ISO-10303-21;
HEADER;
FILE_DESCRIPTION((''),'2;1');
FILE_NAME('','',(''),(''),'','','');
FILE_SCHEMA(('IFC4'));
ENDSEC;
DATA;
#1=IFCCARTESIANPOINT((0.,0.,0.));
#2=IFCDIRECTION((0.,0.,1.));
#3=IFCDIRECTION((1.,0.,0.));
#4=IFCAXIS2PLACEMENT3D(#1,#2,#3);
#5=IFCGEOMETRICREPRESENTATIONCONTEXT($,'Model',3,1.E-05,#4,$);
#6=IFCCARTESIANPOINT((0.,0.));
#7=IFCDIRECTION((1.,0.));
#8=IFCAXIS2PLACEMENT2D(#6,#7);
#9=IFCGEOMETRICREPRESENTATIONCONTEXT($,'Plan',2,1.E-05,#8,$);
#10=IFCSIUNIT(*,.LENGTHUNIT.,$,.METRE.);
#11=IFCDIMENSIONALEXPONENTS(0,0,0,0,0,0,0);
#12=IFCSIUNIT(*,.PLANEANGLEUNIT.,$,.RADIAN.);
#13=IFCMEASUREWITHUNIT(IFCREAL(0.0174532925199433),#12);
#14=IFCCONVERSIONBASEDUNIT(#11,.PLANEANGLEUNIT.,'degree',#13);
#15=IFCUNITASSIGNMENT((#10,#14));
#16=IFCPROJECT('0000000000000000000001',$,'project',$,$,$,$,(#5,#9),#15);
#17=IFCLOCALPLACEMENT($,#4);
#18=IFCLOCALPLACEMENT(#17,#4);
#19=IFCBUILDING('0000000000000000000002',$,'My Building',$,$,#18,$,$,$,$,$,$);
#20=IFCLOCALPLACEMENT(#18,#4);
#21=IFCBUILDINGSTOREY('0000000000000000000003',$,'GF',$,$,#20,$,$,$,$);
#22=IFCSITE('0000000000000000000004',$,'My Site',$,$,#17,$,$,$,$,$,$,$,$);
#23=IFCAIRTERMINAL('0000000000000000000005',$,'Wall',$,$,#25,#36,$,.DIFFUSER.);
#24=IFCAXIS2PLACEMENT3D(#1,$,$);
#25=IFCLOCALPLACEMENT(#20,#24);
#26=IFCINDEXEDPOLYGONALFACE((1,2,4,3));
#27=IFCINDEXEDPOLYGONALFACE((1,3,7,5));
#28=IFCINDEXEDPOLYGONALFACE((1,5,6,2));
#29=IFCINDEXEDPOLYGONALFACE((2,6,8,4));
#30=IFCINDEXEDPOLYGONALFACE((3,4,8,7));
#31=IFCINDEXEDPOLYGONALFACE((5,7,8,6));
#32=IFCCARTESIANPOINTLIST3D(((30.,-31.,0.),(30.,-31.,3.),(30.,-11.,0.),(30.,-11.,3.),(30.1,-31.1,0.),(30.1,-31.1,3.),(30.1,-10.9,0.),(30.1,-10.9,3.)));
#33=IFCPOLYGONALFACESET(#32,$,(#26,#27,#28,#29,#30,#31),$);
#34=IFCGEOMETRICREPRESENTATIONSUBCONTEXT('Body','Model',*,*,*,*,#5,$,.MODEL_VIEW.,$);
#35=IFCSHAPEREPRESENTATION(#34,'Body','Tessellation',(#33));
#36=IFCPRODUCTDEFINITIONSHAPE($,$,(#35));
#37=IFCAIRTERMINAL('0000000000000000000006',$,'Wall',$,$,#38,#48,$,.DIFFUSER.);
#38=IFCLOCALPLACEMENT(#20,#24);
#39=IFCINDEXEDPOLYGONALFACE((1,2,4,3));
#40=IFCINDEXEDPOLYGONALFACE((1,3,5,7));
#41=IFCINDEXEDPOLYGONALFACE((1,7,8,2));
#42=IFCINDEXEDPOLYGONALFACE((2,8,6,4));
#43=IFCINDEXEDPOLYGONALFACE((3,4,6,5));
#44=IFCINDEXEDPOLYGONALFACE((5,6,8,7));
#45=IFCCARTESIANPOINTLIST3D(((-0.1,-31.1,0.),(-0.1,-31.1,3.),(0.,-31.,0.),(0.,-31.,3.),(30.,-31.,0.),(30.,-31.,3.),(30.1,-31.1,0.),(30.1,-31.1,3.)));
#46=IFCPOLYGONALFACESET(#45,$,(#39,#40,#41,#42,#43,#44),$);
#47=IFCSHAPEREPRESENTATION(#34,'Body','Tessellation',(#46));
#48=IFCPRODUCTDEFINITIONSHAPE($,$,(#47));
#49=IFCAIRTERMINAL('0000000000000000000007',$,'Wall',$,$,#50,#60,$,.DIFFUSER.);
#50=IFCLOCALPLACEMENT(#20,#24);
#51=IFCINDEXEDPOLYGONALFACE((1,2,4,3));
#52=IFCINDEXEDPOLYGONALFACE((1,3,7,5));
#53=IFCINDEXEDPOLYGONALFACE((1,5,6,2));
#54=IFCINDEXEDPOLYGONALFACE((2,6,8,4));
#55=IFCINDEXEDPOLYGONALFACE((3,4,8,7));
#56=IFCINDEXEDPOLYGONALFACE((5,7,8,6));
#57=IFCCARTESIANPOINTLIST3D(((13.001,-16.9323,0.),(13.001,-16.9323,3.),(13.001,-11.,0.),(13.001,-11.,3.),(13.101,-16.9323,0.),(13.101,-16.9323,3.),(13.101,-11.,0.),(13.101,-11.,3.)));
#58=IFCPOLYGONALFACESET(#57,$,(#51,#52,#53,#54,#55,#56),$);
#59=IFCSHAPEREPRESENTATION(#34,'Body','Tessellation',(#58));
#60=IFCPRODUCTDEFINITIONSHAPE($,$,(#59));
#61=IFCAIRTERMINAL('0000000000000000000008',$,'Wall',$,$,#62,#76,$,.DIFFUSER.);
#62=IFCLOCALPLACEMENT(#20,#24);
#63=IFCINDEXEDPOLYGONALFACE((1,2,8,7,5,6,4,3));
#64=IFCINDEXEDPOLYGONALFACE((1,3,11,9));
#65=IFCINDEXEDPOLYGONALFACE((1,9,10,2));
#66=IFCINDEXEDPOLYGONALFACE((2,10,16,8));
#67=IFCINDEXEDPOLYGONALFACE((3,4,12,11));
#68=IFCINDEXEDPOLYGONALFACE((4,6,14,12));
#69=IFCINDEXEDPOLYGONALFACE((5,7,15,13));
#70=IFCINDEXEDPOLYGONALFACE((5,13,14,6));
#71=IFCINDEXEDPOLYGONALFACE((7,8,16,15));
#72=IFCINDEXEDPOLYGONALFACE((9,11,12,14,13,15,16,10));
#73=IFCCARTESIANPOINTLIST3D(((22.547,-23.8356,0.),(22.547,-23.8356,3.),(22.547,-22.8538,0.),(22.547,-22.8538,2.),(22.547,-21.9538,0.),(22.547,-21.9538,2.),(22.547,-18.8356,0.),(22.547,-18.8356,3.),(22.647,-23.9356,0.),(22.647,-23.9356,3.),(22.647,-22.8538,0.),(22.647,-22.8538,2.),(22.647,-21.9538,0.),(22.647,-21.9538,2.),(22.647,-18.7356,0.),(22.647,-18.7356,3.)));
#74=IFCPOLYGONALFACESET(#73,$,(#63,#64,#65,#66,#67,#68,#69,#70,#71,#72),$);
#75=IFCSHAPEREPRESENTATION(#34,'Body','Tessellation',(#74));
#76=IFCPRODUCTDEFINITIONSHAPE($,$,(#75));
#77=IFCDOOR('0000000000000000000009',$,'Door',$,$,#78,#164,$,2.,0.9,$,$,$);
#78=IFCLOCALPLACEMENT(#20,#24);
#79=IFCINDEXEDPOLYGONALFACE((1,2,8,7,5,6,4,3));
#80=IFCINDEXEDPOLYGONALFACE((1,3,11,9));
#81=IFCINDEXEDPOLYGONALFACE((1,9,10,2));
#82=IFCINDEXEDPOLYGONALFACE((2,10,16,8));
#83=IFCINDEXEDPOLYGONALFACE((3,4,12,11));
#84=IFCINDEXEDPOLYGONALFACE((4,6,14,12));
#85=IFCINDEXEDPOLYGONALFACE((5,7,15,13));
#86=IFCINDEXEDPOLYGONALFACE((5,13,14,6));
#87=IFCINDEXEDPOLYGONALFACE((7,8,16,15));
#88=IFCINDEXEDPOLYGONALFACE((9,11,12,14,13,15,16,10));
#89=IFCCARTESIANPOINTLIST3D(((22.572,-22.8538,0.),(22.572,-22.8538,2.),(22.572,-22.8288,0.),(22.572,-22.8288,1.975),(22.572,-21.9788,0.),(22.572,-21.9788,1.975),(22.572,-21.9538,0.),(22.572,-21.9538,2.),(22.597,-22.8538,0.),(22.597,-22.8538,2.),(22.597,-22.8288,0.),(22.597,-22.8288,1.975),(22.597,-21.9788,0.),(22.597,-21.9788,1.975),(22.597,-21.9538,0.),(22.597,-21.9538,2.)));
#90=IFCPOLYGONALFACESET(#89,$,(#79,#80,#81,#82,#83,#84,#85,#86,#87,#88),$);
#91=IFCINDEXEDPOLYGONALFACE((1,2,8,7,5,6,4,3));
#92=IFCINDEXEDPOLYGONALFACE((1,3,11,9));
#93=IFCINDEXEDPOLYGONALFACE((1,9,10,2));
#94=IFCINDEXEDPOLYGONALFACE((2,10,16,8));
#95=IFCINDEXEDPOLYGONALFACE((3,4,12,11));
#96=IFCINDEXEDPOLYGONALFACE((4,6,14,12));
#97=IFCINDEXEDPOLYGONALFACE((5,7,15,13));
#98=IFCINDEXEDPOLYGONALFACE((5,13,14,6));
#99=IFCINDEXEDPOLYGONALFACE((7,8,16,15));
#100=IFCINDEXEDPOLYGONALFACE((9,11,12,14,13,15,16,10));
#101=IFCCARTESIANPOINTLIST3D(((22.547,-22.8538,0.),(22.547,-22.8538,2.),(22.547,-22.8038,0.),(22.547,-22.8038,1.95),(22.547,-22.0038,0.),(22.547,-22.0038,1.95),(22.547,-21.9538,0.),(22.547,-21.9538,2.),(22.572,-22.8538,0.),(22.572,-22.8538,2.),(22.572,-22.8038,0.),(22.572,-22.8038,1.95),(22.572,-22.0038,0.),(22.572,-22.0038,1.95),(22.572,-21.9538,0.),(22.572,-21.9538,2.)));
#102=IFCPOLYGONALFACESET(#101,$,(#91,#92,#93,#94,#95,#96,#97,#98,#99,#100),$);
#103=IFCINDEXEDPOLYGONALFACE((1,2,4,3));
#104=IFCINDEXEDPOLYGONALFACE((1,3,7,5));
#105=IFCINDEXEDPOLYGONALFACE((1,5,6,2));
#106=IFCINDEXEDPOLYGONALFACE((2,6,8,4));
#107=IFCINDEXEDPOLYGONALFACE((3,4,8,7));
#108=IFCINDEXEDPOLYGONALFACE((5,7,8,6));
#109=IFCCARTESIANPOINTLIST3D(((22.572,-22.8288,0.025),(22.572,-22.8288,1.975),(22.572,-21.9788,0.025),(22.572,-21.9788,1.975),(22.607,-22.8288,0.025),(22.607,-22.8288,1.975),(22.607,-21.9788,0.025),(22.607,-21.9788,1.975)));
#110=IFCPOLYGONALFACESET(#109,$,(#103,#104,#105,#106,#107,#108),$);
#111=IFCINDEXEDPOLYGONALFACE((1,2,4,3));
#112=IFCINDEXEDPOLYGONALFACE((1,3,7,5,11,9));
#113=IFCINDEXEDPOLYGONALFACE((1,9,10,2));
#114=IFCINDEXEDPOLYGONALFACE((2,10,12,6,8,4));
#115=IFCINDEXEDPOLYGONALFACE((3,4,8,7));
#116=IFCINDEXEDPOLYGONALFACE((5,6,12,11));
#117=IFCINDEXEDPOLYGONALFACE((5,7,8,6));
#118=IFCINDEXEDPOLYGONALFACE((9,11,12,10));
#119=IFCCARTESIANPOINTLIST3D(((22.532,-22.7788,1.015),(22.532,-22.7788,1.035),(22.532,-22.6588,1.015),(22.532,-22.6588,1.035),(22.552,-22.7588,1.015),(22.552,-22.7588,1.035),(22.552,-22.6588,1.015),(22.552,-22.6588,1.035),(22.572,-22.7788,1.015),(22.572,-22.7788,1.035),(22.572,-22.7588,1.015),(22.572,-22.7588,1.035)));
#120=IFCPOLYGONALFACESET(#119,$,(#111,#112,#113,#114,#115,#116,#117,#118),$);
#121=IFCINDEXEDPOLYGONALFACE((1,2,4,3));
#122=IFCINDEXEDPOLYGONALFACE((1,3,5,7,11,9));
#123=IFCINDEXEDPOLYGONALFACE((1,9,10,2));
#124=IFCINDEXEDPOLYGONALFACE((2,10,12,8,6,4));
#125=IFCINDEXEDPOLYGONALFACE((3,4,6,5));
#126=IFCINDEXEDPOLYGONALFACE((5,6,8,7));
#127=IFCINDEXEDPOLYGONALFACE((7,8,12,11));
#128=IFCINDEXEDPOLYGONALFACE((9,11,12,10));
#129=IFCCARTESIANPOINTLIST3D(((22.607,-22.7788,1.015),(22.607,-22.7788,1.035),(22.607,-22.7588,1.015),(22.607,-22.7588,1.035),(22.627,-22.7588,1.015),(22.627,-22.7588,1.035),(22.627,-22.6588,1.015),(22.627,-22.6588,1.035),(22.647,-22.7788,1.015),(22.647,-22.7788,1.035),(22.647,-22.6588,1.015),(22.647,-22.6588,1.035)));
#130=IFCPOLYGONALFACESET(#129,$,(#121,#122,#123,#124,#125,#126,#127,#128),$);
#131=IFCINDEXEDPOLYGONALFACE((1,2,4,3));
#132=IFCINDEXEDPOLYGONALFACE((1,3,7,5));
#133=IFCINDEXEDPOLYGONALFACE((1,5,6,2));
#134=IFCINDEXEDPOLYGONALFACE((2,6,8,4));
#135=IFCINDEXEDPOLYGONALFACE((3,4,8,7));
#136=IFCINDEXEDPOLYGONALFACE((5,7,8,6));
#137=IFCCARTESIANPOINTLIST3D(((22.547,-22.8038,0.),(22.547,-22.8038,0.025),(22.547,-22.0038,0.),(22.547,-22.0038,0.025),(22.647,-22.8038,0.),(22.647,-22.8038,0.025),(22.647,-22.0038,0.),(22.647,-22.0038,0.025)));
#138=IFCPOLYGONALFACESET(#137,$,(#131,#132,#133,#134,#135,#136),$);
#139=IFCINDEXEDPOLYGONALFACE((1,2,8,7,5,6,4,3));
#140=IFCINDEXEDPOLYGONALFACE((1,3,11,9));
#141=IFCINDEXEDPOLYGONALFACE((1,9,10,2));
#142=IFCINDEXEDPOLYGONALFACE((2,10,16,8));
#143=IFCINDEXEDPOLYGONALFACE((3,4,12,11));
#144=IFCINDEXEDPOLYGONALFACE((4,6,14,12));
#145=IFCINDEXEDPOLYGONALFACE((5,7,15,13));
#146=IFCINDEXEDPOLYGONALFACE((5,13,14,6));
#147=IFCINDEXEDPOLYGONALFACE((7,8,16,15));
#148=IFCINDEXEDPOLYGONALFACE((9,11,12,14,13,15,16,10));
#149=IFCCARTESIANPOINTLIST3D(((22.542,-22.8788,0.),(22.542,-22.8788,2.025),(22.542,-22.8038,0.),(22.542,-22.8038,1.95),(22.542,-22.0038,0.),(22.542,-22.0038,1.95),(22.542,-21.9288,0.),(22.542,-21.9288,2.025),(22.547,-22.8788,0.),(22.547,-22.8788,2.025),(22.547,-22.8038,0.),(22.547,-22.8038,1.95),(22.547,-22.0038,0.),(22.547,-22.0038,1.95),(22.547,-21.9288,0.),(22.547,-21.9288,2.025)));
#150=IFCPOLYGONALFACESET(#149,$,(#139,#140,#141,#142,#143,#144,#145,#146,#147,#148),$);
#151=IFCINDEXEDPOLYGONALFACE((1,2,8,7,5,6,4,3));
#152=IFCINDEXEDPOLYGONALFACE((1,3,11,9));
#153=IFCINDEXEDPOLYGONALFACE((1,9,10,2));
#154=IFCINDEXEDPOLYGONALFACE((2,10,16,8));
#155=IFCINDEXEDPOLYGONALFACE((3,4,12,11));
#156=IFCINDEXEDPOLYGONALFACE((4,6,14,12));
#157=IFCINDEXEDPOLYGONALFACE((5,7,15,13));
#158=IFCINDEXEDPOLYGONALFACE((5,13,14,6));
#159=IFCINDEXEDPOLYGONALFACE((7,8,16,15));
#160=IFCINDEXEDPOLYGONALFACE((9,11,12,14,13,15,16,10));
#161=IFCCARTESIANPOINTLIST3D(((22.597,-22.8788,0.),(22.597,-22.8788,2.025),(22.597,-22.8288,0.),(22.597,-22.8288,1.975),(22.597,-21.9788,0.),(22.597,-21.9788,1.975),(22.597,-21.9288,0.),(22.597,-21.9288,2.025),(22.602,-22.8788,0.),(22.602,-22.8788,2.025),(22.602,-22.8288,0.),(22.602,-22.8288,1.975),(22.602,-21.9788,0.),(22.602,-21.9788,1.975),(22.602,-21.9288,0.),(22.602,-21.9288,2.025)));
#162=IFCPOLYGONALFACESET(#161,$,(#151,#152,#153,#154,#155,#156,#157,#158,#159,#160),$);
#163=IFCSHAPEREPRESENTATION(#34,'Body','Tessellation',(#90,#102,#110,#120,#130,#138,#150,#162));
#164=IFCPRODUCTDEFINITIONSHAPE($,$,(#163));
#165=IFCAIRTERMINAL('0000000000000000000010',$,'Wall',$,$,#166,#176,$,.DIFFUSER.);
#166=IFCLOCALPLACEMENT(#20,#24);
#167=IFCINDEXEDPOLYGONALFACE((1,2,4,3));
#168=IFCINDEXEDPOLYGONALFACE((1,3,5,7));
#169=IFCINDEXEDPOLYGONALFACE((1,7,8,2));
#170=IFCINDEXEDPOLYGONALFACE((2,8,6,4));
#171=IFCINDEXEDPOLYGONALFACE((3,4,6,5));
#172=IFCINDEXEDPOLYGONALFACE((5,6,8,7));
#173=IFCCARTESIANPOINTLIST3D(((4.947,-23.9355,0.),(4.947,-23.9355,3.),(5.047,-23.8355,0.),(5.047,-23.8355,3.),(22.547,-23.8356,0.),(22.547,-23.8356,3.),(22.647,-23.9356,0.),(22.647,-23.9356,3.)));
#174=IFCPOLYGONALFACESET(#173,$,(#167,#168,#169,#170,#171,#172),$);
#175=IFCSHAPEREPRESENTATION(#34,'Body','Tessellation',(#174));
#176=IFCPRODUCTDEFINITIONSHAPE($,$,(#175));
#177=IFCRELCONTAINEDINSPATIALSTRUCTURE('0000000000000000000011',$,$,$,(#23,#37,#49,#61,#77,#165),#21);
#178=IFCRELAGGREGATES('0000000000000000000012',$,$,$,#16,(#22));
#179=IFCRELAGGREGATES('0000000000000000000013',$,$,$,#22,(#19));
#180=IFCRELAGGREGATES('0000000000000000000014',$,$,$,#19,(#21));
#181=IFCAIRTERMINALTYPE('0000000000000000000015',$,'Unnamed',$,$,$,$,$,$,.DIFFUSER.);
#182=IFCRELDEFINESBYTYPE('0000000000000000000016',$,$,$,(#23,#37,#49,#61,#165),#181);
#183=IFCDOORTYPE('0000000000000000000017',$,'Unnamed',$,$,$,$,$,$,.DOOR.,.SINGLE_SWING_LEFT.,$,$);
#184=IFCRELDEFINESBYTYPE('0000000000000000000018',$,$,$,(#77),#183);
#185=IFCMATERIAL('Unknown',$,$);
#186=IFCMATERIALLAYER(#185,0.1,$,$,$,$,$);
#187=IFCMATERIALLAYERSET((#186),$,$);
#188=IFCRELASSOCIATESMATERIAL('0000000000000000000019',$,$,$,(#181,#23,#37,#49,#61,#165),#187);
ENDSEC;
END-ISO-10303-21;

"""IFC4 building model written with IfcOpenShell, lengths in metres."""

from ifc_helpers import new_model, entity, si_unit, converted_unit, frame, origin_with_axes, origin_2d_with_axis, place, context, subcontext, project, spatial, line, indexed_curve, outline, extrude, shape, source, transform, mapped, material, layer, layer_set, layer_usage, type_object, type_shapes, element, fill, save


model = new_model("IFC4")

# Units and contexts
model_context = context("Model", 3, precision=1e-05, world=origin_with_axes())
plan_context = context("Plan", 2, precision=1e-05, world=origin_2d_with_axis())
body_context_1 = subcontext(model_context, "Body", "Model", "MODEL_VIEW")
body_context_2 = subcontext(plan_context, "Body", "Plan", "PLAN_VIEW")
ifc_project = project(units=[si_unit("LENGTHUNIT", "METRE"), converted_unit("PLANEANGLEUNIT", "degree", entity("IfcReal", 0.0174532925199433), si_unit("PLANEANGLEUNIT", "RADIAN"), dimensions=[0, 0, 0, 0, 0, 0, 0])], contexts=[model_context, plan_context])

# Site, building, storey
site_placement = place(None, origin_with_axes())
site = spatial("IfcSite", under=ifc_project, at=site_placement, Name="My Site")
building_placement = place(site_placement, origin_with_axes())
building = spatial("IfcBuilding", under=site, at=building_placement, Name="My Building")
storey_placement = place(building_placement, origin_with_axes())
storey = spatial("IfcBuildingStorey", under=building, at=storey_placement, Name="GF")

# Air terminals
ifc_material = material(Name="Unknown")
ifc_layer = layer(ifc_material, 0.1)
ifc_layer_set = layer_set([ifc_layer])
ifc_layer_usage_1 = layer_usage(ifc_layer_set, "AXIS2", "POSITIVE", 0.0)
air_terminal_type = type_object("IfcAirTerminalType", Name="Unnamed", PredefinedType="DIFFUSER", material=ifc_layer_set)
air_terminal_1_placement = place(storey_placement, frame((30.0, -11.0, 0.0), z_axis=(0.0, 0.0, 1.0), x_axis=(0.0, -1.0, 0.0)))
element("IfcAirTerminal", 1, at=air_terminal_1_placement, inside=storey, type_object=air_terminal_type, material=ifc_layer_usage_1, Name="Wall", PredefinedType="DIFFUSER", context=body_context_1, shape_type="SweptSolid", body=[
    extrude(outline(indexed_curve([(0.0, 0.0), (-0.1, 0.1), (20.1, 0.1), (20.0, 0.0)], segments=[line(1, 2, 3, 4, 1)])), origin_with_axes(), (0.0, 0.0, 1.0), 3.0),
])
ifc_layer_usage_2 = layer_usage(ifc_layer_set, "AXIS2", "POSITIVE", 0.0)
air_terminal_2_placement = place(storey_placement, frame((30.0, -31.0, 0.0), z_axis=(0.0, 0.0, 1.0), x_axis=(-1.0, 0.0, 0.0)))
element("IfcAirTerminal", 2, at=air_terminal_2_placement, inside=storey, type_object=air_terminal_type, material=ifc_layer_usage_2, Name="Wall", PredefinedType="DIFFUSER", context=body_context_1, shape_type="SweptSolid", body=[
    extrude(outline(indexed_curve([(0.0, 0.0), (-0.1, 0.1), (30.1, 0.1), (30.0, 0.0)], segments=[line(1, 2, 3, 4, 1)])), origin_with_axes(), (0.0, 0.0, 1.0), 3.0),
])
ifc_layer_usage_3 = layer_usage(ifc_layer_set, "AXIS2", "POSITIVE", 0.0)
air_terminal_3_placement = place(storey_placement, frame((13.101, -16.9323, 0.0), z_axis=(0.0, 0.0, 1.0), x_axis=(0.0, 1.0, 0.0)))
element("IfcAirTerminal", 3, at=air_terminal_3_placement, inside=storey, type_object=air_terminal_type, material=ifc_layer_usage_3, Name="Wall", PredefinedType="DIFFUSER", context=body_context_1, shape_type="SweptSolid", body=[
    extrude(outline(indexed_curve([(0.0, 0.0), (0.0, 0.1), (5.9323, 0.1), (5.9323, 0.0)], segments=[line(1, 2, 3, 4, 1)])), origin_with_axes(), (0.0, 0.0, 1.0), 3.0),
])

# Air terminal, opening, door
ifc_layer_usage_4 = layer_usage(ifc_layer_set, "AXIS2", "POSITIVE", 0.0)
air_terminal_4_placement = place(storey_placement, frame((22.547, -18.8356, 0.0), z_axis=(0.0, 0.0, 1.0), x_axis=(0.0, -1.0, 0.0)))
air_terminal_4 = element("IfcAirTerminal", 4, at=air_terminal_4_placement, inside=storey, type_object=air_terminal_type, material=ifc_layer_usage_4, Name="Wall", PredefinedType="DIFFUSER", context=body_context_1, shape_type="SweptSolid", body=[
    extrude(outline(indexed_curve([(0.0, 0.0), (-0.1, 0.1), (5.1, 0.1), (5.0, 0.0)], segments=[line(1, 2, 3, 4, 1)])), origin_with_axes(), (0.0, 0.0, 1.0), 3.0),
])
shared_shape_1 = source(origin_with_axes(), body_context_1, "Body", "SweptSolid", [
    extrude(outline(indexed_curve([(0.0, 0.0), (0.9, 0.0), (0.9, 2.0), (0.0, 2.0)], segments=[line(1, 2, 3, 4, 1)])), frame((0.0, -0.6, 0.0), z_axis=(0.0, -1.0, 0.0), x_axis=(1.0, 0.0, 0.0)), (0.0, 0.0, -1.0), 1.2),
])
opening_1_placement = place(air_terminal_4_placement, frame((3.1182, 0.0, 0.0), z_axis=(0.0, 0.0, 1.0), x_axis=(1.0, 0.0, 0.0)))
opening_1 = element("IfcOpeningElement", 5, at=opening_1_placement, cuts=air_terminal_4, PredefinedType="OPENING", context=body_context_1, shape_type="MappedRepresentation", body=[
    mapped(shared_shape_1, transform((0.0, 0.0, 0.0), x_axis=(1.0, 0.0, 0.0), y_axis=(0.0, 1.0, 0.0), z_axis=(0.0, 0.0, 1.0), scale=1.0)),
])
door_type = type_object("IfcDoorType", Name="Unnamed", OperationType="SINGLE_SWING_LEFT", PredefinedType="DOOR")
shared_shape_2 = source(origin_with_axes(), body_context_1, "Body", "SweptSolid", [
    extrude(outline(indexed_curve([(0.0, 0.0), (0.0, 2.0), (0.9, 2.0), (0.9, 0.0), (0.875, 0.0), (0.875, 1.975), (0.025, 1.975), (0.025, 0.0)], segments=[line(1, 2, 3, 4, 5, 6, 7, 8, 1)])), frame((0.0, 0.025, 0.0), z_axis=(0.0, -1.0, 0.0), x_axis=(1.0, 0.0, 0.0)), (0.0, 0.0, -1.0), 0.025),
    extrude(outline(indexed_curve([(0.0, 0.0), (0.0, 2.0), (0.9, 2.0), (0.9, 0.0), (0.85, 0.0), (0.85, 1.95), (0.05, 1.95), (0.05, 0.0)], segments=[line(1, 2, 3, 4, 5, 6, 7, 8, 1)])), frame((0.0, 0.0, 0.0), z_axis=(0.0, -1.0, 0.0), x_axis=(1.0, 0.0, 0.0)), (0.0, 0.0, -1.0), 0.025),
    extrude(outline(indexed_curve([(0.0, 0.0), (0.85, 0.0), (0.85, 0.035), (0.0, 0.035)], segments=[line(1, 2, 3, 4, 1)])), frame((0.025, 0.025, 0.025), z_axis=(0.0, 0.0, 1.0), x_axis=(1.0, 0.0, 0.0)), (0.0, 0.0, 1.0), 1.95),
    extrude(outline(indexed_curve([(0.0, 0.0), (0.0, -0.04), (-0.12, -0.04), (-0.12, -0.02), (-0.02, -0.02), (-0.02, 0.0)], segments=[line(1, 2, 3, 4, 5, 6, 1)])), frame((0.825, 0.025, 1.015), z_axis=(0.0, 0.0, 1.0), x_axis=(1.0, 0.0, 0.0)), (0.0, 0.0, 1.0), 0.02),
    extrude(outline(indexed_curve([(0.0, 0.0), (0.0, 0.04), (-0.12, 0.04), (-0.12, 0.02), (-0.02, 0.02), (-0.02, 0.0)], segments=[line(1, 2, 3, 4, 5, 6, 1)])), frame((0.825, 0.06, 1.015), z_axis=(0.0, 0.0, 1.0), x_axis=(1.0, 0.0, 0.0)), (0.0, 0.0, 1.0), 0.02),
    extrude(outline(indexed_curve([(0.0, 0.0), (0.8, 0.0), (0.8, 0.1), (0.0, 0.1)], segments=[line(1, 2, 3, 4, 1)])), frame((0.05, 0.0, 0.0), z_axis=(0.0, 0.0, 1.0), x_axis=(1.0, 0.0, 0.0)), (0.0, 0.0, 1.0), 0.025),
    extrude(outline(indexed_curve([(0.0, 0.0), (0.0, 2.025), (0.95, 2.025), (0.95, 0.0), (0.875, 0.0), (0.875, 1.95), (0.075, 1.95), (0.075, 0.0)], segments=[line(1, 2, 3, 4, 5, 6, 7, 8, 1)])), frame((-0.025, -0.005, 0.0), z_axis=(0.0, -1.0, 0.0), x_axis=(1.0, 0.0, 0.0)), (0.0, 0.0, -1.0), 0.005),
    extrude(outline(indexed_curve([(0.0, 0.0), (0.0, 2.025), (0.95, 2.025), (0.95, 0.0), (0.9, 0.0), (0.9, 1.975), (0.05, 1.975), (0.05, 0.0)], segments=[line(1, 2, 3, 4, 5, 6, 7, 8, 1)])), frame((-0.025, 0.05, 0.0), z_axis=(0.0, -1.0, 0.0), x_axis=(1.0, 0.0, 0.0)), (0.0, 0.0, -1.0), 0.005),
])
shared_shape_3 = source(origin_with_axes(), body_context_2, "Body", "Curve2D", [
    entity("IfcIndexedPolyCurve", entity("IfcCartesianPointList2D", [[0.0, 0.0], [0.0, 0.05], [0.025, 0.05], [0.025, 0.025], [0.05, 0.025], [0.05, 0.0]]), [entity("IfcLineIndex", [1, 2, 3, 4, 5, 6, 1])]),
    entity("IfcIndexedPolyCurve", entity("IfcCartesianPointList2D", [[0.9, 0.0], [0.9, 0.05], [0.875, 0.05], [0.875, 0.025], [0.85, 0.025], [0.85, 0.0]]), [entity("IfcLineIndex", [1, 2, 3, 4, 5, 6, 1])]),
    entity("IfcTrimmedCurve", entity("IfcEllipse", entity("IfcAxis2Placement2D", entity("IfcCartesianPoint", [0.06, 0.05]), entity("IfcDirection", [1.0, 0.0])), 0.815, 0.85), [entity("IfcCartesianPoint", [0.875, 0.05])], [entity("IfcCartesianPoint", [0.06, 0.9])], True, "CARTESIAN"),
    entity("IfcIndexedPolyCurve", entity("IfcCartesianPointList2D", [[0.025, 0.05], [0.06, 0.05], [0.06, 0.9], [0.025, 0.9]]), [entity("IfcLineIndex", [1, 2, 3, 4, 1])]),
])
type_shapes(door_type, [shared_shape_2, shared_shape_3])
door_1_placement = place(opening_1_placement, frame((0.0, 0.0, 0.0), z_axis=(0.0, 0.0, 1.0), x_axis=(1.0, 0.0, 0.0)))
door_1 = element("IfcDoor", 6, at=door_1_placement, inside=storey, type_object=door_type, Name="Door", OverallHeight=2.0, OverallWidth=0.9, shapes=[
    shape(body_context_1, "Body", "MappedRepresentation", [mapped(shared_shape_2, transform((0.0, 0.0, 0.0), x_axis=(1.0, 0.0, 0.0), y_axis=(0.0, 1.0, 0.0), z_axis=(0.0, 0.0, 1.0), scale=1.0))]),
    shape(body_context_2, "Body", "MappedRepresentation", [mapped(shared_shape_3, transform((0.0, 0.0, 0.0), x_axis=(1.0, 0.0, 0.0), y_axis=(0.0, 1.0, 0.0), z_axis=(0.0, 0.0, 1.0), scale=1.0))]),
])
fill(opening_1, door_1)

# Air terminal
ifc_layer_usage_5 = layer_usage(ifc_layer_set, "AXIS2", "POSITIVE", 0.0)
air_terminal_5_placement = place(storey_placement, frame((22.547, -23.8356, 0.0), z_axis=(0.0, 0.0, 1.0), x_axis=(-1.0, 0.0, 0.0)))
element("IfcAirTerminal", 7, at=air_terminal_5_placement, inside=storey, type_object=air_terminal_type, material=ifc_layer_usage_5, Name="Wall", PredefinedType="DIFFUSER", context=body_context_1, shape_type="SweptSolid", body=[
    extrude(outline(indexed_curve([(0.0, 0.0), (-0.1, 0.1), (17.6, 0.1), (17.5, 0.0)], segments=[line(1, 2, 3, 4, 1)])), origin_with_axes(), (0.0, 0.0, 1.0), 3.0),
])

save(model, "model.ifc")
